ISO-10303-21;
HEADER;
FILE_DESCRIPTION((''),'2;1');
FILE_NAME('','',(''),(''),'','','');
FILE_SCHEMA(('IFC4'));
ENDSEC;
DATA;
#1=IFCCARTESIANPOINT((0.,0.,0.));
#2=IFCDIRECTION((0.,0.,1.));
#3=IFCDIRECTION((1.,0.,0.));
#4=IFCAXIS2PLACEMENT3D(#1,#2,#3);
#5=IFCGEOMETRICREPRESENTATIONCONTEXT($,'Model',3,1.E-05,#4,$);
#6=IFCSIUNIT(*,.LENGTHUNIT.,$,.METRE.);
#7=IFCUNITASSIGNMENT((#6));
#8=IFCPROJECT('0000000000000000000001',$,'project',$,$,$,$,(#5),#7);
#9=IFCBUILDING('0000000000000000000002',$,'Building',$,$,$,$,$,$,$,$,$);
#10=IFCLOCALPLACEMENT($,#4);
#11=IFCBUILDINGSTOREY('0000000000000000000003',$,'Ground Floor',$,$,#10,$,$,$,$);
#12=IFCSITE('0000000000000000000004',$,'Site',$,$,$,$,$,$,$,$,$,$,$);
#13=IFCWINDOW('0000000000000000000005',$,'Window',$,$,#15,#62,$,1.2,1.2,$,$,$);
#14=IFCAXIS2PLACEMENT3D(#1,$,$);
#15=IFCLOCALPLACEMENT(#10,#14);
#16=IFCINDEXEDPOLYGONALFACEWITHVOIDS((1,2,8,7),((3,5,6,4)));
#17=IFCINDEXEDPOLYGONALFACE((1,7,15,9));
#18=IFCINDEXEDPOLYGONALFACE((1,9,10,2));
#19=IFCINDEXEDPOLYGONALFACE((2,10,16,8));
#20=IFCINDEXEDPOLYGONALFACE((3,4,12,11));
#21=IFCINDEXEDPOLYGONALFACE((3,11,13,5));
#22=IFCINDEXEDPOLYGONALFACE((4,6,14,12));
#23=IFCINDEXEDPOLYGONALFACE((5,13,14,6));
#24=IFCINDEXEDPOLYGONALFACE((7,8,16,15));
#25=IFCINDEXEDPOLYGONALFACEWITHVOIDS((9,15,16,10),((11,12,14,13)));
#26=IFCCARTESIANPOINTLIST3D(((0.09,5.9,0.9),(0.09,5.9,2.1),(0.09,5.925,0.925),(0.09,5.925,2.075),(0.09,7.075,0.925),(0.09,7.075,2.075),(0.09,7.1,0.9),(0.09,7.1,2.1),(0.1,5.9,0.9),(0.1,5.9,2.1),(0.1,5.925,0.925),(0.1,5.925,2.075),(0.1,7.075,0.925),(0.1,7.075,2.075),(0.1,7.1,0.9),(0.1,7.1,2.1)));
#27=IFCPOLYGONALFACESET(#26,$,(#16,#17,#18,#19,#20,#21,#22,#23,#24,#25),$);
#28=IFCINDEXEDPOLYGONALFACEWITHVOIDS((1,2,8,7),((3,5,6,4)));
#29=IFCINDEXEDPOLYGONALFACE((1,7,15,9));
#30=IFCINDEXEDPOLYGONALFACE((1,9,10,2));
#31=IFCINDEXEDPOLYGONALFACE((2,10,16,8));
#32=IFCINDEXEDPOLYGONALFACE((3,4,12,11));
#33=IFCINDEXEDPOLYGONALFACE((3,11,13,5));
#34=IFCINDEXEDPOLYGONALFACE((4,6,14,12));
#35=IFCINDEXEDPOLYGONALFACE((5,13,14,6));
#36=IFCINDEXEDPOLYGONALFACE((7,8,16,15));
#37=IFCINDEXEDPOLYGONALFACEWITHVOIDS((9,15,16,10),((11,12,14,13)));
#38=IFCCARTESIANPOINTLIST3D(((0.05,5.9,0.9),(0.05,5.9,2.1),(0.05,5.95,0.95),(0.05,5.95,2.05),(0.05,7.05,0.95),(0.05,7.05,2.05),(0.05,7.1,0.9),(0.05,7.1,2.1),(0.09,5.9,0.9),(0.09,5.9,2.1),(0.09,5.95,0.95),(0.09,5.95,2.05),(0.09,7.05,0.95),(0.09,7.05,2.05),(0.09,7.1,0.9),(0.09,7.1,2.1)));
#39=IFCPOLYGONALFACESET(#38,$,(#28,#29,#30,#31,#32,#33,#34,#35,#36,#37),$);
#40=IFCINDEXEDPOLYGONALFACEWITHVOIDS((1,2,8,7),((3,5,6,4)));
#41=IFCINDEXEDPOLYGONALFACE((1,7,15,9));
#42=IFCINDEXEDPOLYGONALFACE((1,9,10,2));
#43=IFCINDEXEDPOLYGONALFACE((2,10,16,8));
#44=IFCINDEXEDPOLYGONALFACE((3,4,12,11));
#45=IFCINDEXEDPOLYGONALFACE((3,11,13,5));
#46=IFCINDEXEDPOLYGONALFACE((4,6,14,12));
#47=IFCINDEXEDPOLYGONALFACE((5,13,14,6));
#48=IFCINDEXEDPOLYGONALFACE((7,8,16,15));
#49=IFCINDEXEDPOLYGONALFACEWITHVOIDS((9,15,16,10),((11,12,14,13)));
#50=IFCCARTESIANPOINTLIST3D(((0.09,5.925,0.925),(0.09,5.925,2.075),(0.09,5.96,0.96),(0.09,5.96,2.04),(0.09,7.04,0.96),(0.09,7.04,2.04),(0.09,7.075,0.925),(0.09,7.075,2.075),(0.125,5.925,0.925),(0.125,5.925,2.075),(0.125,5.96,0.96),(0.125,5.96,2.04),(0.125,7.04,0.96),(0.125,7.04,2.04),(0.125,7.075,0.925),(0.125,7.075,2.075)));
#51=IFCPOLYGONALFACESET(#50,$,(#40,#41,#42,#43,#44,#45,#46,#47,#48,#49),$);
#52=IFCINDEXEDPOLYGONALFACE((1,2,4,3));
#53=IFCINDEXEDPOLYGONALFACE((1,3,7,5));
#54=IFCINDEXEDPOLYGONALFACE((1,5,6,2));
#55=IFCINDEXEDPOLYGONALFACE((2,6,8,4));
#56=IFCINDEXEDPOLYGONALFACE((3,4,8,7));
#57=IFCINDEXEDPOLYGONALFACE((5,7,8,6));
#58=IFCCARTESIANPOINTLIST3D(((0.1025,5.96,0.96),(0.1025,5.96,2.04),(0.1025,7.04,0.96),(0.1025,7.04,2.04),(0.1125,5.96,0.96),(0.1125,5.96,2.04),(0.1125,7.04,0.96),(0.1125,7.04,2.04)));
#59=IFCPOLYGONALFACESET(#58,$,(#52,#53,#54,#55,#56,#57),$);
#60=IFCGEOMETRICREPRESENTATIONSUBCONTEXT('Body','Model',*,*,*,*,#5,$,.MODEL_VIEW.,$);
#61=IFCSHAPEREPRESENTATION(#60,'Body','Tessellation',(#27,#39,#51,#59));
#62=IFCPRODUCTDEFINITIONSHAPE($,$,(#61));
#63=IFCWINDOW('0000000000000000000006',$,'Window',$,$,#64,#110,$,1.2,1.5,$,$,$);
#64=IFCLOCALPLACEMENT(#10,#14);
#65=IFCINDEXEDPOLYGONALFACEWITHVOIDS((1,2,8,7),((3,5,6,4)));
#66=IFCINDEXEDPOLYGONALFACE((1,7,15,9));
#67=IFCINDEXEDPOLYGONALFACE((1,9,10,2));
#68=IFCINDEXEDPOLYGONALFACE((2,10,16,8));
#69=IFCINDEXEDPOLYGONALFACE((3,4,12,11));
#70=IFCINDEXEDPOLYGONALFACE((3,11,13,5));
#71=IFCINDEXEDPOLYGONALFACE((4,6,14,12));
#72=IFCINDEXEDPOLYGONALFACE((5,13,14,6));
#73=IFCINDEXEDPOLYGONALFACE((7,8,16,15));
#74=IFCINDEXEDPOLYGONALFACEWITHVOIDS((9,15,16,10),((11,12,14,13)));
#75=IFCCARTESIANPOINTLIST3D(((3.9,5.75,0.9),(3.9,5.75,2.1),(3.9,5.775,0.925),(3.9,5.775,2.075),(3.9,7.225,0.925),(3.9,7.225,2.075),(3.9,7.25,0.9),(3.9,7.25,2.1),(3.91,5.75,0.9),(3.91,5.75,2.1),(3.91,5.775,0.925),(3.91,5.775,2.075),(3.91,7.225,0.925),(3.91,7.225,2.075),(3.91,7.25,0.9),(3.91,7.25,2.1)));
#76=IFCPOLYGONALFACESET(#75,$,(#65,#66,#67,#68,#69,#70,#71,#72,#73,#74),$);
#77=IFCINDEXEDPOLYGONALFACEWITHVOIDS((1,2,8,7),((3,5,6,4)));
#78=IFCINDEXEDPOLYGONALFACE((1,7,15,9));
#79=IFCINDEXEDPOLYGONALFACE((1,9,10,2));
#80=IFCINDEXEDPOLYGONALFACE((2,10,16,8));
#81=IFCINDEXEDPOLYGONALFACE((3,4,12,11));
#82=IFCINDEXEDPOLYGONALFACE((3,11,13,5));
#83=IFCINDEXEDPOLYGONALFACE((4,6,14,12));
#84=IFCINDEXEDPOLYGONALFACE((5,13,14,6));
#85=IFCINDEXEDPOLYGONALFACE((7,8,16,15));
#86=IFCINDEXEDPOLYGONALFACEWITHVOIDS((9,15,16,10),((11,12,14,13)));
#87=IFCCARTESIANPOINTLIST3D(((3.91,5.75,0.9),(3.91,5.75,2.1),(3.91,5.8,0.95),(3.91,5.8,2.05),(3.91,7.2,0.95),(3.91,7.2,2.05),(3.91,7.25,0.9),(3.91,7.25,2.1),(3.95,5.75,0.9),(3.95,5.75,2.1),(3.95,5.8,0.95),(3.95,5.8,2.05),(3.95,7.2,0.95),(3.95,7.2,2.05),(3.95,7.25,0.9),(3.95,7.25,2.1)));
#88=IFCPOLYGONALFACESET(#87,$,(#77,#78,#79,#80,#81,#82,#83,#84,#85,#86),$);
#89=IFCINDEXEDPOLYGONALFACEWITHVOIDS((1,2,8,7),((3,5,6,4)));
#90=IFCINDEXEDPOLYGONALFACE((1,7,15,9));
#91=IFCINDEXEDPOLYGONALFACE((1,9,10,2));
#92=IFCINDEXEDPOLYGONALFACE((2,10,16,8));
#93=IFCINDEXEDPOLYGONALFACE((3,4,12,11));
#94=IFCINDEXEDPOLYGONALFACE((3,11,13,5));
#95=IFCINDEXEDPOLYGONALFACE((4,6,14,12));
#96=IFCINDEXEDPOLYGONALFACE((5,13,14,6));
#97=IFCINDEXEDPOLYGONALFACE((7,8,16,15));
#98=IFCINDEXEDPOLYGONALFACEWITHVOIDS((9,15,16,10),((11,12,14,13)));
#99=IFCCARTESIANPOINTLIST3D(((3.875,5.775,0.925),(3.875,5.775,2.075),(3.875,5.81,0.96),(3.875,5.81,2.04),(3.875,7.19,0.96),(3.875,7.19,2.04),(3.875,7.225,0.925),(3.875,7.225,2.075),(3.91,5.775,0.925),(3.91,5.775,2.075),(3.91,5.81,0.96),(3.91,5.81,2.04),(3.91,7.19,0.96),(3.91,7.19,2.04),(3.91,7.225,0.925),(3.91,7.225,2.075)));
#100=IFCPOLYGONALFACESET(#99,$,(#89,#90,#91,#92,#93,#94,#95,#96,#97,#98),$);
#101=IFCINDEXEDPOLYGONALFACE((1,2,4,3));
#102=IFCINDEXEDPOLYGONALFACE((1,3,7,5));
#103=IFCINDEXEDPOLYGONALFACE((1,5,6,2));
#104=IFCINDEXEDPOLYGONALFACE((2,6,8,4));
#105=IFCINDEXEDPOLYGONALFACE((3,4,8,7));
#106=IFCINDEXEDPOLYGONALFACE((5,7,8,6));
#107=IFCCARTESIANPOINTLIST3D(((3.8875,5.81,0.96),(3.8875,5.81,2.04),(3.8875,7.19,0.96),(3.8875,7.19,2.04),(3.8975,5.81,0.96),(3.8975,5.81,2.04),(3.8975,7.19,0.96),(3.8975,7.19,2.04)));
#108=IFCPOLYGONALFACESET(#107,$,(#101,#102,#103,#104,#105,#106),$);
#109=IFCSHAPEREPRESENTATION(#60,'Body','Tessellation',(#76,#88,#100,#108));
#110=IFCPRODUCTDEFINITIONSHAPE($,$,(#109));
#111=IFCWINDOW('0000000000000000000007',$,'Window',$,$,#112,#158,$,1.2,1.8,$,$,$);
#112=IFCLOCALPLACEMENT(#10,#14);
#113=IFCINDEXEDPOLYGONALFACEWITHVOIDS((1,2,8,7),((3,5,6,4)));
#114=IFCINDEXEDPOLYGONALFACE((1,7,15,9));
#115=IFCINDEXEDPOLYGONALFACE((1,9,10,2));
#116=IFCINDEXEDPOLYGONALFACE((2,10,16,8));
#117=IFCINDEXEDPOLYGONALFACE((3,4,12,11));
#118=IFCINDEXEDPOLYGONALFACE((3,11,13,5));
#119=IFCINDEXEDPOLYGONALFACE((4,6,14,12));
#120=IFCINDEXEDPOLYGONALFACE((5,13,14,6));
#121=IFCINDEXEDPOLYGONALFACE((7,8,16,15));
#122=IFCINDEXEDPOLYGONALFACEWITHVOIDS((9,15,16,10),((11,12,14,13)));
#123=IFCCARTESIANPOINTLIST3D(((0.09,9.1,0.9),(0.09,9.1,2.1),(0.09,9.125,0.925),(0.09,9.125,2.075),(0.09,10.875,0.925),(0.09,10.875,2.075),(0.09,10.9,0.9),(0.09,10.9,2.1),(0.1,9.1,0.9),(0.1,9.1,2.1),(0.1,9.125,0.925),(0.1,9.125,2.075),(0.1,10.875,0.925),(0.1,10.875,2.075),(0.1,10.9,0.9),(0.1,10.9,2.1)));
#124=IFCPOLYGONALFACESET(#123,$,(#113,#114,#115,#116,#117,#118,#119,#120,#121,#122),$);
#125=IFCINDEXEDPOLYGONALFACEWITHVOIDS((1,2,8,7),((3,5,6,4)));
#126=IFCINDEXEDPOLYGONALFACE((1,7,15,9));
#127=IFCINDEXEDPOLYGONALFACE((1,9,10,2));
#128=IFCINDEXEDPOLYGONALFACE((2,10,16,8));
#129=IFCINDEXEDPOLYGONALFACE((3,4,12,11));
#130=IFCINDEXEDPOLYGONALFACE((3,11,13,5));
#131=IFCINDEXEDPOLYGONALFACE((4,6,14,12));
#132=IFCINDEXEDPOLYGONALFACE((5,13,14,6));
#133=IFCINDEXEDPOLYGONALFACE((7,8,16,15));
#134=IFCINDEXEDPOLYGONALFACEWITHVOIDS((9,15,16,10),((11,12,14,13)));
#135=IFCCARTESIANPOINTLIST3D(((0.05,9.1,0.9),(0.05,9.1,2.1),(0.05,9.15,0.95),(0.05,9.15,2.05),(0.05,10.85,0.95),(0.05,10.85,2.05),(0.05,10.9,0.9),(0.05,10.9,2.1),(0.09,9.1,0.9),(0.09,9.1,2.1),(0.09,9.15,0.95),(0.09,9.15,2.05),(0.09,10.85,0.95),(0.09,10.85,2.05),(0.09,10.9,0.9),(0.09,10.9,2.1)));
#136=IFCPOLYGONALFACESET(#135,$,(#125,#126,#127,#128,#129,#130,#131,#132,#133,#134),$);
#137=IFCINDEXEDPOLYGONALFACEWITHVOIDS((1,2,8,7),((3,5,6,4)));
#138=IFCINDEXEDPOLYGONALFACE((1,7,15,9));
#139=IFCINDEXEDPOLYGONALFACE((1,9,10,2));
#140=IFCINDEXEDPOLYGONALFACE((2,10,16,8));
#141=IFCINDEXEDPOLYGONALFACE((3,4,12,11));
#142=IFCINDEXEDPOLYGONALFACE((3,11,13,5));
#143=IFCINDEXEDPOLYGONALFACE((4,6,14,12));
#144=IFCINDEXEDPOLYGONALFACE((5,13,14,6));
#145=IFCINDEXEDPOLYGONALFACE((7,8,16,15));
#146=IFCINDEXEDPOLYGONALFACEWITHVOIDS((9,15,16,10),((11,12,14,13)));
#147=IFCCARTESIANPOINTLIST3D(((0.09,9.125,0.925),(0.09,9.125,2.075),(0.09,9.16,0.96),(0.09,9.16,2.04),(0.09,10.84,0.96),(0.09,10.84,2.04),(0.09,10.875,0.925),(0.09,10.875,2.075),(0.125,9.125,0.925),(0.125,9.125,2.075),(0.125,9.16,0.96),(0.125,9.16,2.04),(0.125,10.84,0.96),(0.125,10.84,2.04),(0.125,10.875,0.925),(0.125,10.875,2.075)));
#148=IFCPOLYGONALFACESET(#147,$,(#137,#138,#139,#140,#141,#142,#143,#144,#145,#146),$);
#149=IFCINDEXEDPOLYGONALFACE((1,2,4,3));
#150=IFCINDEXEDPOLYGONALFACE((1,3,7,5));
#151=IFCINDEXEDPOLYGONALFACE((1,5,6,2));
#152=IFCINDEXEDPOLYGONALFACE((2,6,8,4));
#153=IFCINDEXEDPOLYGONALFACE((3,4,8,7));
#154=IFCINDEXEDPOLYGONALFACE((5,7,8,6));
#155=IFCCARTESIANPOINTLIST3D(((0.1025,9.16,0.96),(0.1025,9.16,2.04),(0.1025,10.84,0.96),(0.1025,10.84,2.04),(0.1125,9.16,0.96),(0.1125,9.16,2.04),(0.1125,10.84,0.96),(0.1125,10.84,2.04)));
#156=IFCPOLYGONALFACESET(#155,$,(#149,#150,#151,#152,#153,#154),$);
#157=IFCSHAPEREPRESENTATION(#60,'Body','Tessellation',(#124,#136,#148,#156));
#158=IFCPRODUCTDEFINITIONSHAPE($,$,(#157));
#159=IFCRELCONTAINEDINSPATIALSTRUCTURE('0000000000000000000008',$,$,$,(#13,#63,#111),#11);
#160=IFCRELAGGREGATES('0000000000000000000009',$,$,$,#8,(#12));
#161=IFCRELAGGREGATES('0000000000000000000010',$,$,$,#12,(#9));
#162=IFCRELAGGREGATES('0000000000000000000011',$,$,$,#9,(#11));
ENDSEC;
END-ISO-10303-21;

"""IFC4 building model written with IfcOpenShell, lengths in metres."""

from ifc_helpers import new_model, si_unit, frame, origin_with_axes, place, context, subcontext, project, spatial, line, indexed_curve, outline, extrude, element, save


model = new_model("IFC4")

# Units and contexts
model_context = context("Model", 3, precision=1e-05, world=origin_with_axes())
body_context = subcontext(model_context, "Body", "Model", "MODEL_VIEW")
ifc_project = project(units=[si_unit("LENGTHUNIT", "METRE")], contexts=[model_context])

# Site, building, storey
site = spatial("IfcSite", under=ifc_project, Name="Site")
building = spatial("IfcBuilding", under=site, Name="Building")
storey_placement = place(None, origin_with_axes())
storey = spatial("IfcBuildingStorey", under=building, at=storey_placement, Name="Ground Floor")

# Windows
window_1_placement = place(storey_placement, frame((0.0, 7.1, 0.9), z_axis=(0.0, 0.0, 1.0), x_axis=(0.0, -1.0, 0.0)))
element("IfcWindow", 1, at=window_1_placement, inside=storey, Name="Window", OverallHeight=1.2, OverallWidth=1.2, context=body_context, shape_type="SweptSolid", body=[
    extrude(outline(indexed_curve([(0.0, 0.0), (1.2, 0.0), (1.2, 1.2), (0.0, 1.2)], segments=[line(1, 2, 3, 4, 1)]), holes=[indexed_curve([(0.025, 0.025), (1.175, 0.025), (1.175, 1.175), (0.025, 1.175)], segments=[line(1, 2, 3, 4, 1)])]), frame((0.0, 0.09, 0.0), z_axis=(0.0, -1.0, 0.0), x_axis=(1.0, 0.0, 0.0)), (0.0, 0.0, -1.0), 0.01),
    extrude(outline(indexed_curve([(0.0, 0.0), (1.2, 0.0), (1.2, 1.2), (0.0, 1.2)], segments=[line(1, 2, 3, 4, 1)]), holes=[indexed_curve([(0.05, 0.05), (1.15, 0.05), (1.15, 1.15), (0.05, 1.15)], segments=[line(1, 2, 3, 4, 1)])]), frame((0.0, 0.05, 0.0), z_axis=(0.0, -1.0, 0.0), x_axis=(1.0, 0.0, 0.0)), (0.0, 0.0, -1.0), 0.04),
    extrude(outline(indexed_curve([(0.0, 0.0), (1.15, 0.0), (1.15, 1.15), (0.0, 1.15)], segments=[line(1, 2, 3, 4, 1)]), holes=[indexed_curve([(0.035, 0.035), (1.115, 0.035), (1.115, 1.115), (0.035, 1.115)], segments=[line(1, 2, 3, 4, 1)])]), frame((0.025, 0.09, 0.025), z_axis=(0.0, -1.0, 0.0), x_axis=(1.0, 0.0, 0.0)), (0.0, 0.0, -1.0), 0.035),
    extrude(outline(indexed_curve([(0.035, 0.035), (1.115, 0.035), (1.115, 1.115), (0.035, 1.115)], segments=[line(1, 2, 3, 4, 1)])), frame((0.025, 0.1025, 0.025), z_axis=(0.0, -1.0, 0.0), x_axis=(1.0, 0.0, 0.0)), (0.0, 0.0, -1.0), 0.01),
])
window_2_placement = place(storey_placement, frame((4.0, 5.75, 0.9), z_axis=(0.0, 0.0, 1.0), x_axis=(0.0, 1.0, 0.0)))
element("IfcWindow", 2, at=window_2_placement, inside=storey, Name="Window", OverallHeight=1.2, OverallWidth=1.5, context=body_context, shape_type="SweptSolid", body=[
    extrude(outline(indexed_curve([(0.0, 0.0), (1.5, 0.0), (1.5, 1.2), (0.0, 1.2)], segments=[line(1, 2, 3, 4, 1)]), holes=[indexed_curve([(0.025, 0.025), (1.475, 0.025), (1.475, 1.175), (0.025, 1.175)], segments=[line(1, 2, 3, 4, 1)])]), frame((0.0, 0.09, 0.0), z_axis=(0.0, -1.0, 0.0), x_axis=(1.0, 0.0, 0.0)), (0.0, 0.0, -1.0), 0.01),
    extrude(outline(indexed_curve([(0.0, 0.0), (1.5, 0.0), (1.5, 1.2), (0.0, 1.2)], segments=[line(1, 2, 3, 4, 1)]), holes=[indexed_curve([(0.05, 0.05), (1.45, 0.05), (1.45, 1.15), (0.05, 1.15)], segments=[line(1, 2, 3, 4, 1)])]), frame((0.0, 0.05, 0.0), z_axis=(0.0, -1.0, 0.0), x_axis=(1.0, 0.0, 0.0)), (0.0, 0.0, -1.0), 0.04),
    extrude(outline(indexed_curve([(0.0, 0.0), (1.45, 0.0), (1.45, 1.15), (0.0, 1.15)], segments=[line(1, 2, 3, 4, 1)]), holes=[indexed_curve([(0.035, 0.035), (1.415, 0.035), (1.415, 1.115), (0.035, 1.115)], segments=[line(1, 2, 3, 4, 1)])]), frame((0.025, 0.09, 0.025), z_axis=(0.0, -1.0, 0.0), x_axis=(1.0, 0.0, 0.0)), (0.0, 0.0, -1.0), 0.035),
    extrude(outline(indexed_curve([(0.035, 0.035), (1.415, 0.035), (1.415, 1.115), (0.035, 1.115)], segments=[line(1, 2, 3, 4, 1)])), frame((0.025, 0.1025, 0.025), z_axis=(0.0, -1.0, 0.0), x_axis=(1.0, 0.0, 0.0)), (0.0, 0.0, -1.0), 0.01),
])
window_3_placement = place(storey_placement, frame((0.0, 10.9, 0.9), z_axis=(0.0, 0.0, 1.0), x_axis=(0.0, -1.0, 0.0)))
element("IfcWindow", 3, at=window_3_placement, inside=storey, Name="Window", OverallHeight=1.2, OverallWidth=1.8, context=body_context, shape_type="SweptSolid", body=[
    extrude(outline(indexed_curve([(0.0, 0.0), (1.8, 0.0), (1.8, 1.2), (0.0, 1.2)], segments=[line(1, 2, 3, 4, 1)]), holes=[indexed_curve([(0.025, 0.025), (1.775, 0.025), (1.775, 1.175), (0.025, 1.175)], segments=[line(1, 2, 3, 4, 1)])]), frame((0.0, 0.09, 0.0), z_axis=(0.0, -1.0, 0.0), x_axis=(1.0, 0.0, 0.0)), (0.0, 0.0, -1.0), 0.01),
    extrude(outline(indexed_curve([(0.0, 0.0), (1.8, 0.0), (1.8, 1.2), (0.0, 1.2)], segments=[line(1, 2, 3, 4, 1)]), holes=[indexed_curve([(0.05, 0.05), (1.75, 0.05), (1.75, 1.15), (0.05, 1.15)], segments=[line(1, 2, 3, 4, 1)])]), frame((0.0, 0.05, 0.0), z_axis=(0.0, -1.0, 0.0), x_axis=(1.0, 0.0, 0.0)), (0.0, 0.0, -1.0), 0.04),
    extrude(outline(indexed_curve([(0.0, 0.0), (1.75, 0.0), (1.75, 1.15), (0.0, 1.15)], segments=[line(1, 2, 3, 4, 1)]), holes=[indexed_curve([(0.035, 0.035), (1.715, 0.035), (1.715, 1.115), (0.035, 1.115)], segments=[line(1, 2, 3, 4, 1)])]), frame((0.025, 0.09, 0.025), z_axis=(0.0, -1.0, 0.0), x_axis=(1.0, 0.0, 0.0)), (0.0, 0.0, -1.0), 0.035),
    extrude(outline(indexed_curve([(0.035, 0.035), (1.715, 0.035), (1.715, 1.115), (0.035, 1.115)], segments=[line(1, 2, 3, 4, 1)])), frame((0.025, 0.1025, 0.025), z_axis=(0.0, -1.0, 0.0), x_axis=(1.0, 0.0, 0.0)), (0.0, 0.0, -1.0), 0.01),
])

save(model, "model.ifc")
